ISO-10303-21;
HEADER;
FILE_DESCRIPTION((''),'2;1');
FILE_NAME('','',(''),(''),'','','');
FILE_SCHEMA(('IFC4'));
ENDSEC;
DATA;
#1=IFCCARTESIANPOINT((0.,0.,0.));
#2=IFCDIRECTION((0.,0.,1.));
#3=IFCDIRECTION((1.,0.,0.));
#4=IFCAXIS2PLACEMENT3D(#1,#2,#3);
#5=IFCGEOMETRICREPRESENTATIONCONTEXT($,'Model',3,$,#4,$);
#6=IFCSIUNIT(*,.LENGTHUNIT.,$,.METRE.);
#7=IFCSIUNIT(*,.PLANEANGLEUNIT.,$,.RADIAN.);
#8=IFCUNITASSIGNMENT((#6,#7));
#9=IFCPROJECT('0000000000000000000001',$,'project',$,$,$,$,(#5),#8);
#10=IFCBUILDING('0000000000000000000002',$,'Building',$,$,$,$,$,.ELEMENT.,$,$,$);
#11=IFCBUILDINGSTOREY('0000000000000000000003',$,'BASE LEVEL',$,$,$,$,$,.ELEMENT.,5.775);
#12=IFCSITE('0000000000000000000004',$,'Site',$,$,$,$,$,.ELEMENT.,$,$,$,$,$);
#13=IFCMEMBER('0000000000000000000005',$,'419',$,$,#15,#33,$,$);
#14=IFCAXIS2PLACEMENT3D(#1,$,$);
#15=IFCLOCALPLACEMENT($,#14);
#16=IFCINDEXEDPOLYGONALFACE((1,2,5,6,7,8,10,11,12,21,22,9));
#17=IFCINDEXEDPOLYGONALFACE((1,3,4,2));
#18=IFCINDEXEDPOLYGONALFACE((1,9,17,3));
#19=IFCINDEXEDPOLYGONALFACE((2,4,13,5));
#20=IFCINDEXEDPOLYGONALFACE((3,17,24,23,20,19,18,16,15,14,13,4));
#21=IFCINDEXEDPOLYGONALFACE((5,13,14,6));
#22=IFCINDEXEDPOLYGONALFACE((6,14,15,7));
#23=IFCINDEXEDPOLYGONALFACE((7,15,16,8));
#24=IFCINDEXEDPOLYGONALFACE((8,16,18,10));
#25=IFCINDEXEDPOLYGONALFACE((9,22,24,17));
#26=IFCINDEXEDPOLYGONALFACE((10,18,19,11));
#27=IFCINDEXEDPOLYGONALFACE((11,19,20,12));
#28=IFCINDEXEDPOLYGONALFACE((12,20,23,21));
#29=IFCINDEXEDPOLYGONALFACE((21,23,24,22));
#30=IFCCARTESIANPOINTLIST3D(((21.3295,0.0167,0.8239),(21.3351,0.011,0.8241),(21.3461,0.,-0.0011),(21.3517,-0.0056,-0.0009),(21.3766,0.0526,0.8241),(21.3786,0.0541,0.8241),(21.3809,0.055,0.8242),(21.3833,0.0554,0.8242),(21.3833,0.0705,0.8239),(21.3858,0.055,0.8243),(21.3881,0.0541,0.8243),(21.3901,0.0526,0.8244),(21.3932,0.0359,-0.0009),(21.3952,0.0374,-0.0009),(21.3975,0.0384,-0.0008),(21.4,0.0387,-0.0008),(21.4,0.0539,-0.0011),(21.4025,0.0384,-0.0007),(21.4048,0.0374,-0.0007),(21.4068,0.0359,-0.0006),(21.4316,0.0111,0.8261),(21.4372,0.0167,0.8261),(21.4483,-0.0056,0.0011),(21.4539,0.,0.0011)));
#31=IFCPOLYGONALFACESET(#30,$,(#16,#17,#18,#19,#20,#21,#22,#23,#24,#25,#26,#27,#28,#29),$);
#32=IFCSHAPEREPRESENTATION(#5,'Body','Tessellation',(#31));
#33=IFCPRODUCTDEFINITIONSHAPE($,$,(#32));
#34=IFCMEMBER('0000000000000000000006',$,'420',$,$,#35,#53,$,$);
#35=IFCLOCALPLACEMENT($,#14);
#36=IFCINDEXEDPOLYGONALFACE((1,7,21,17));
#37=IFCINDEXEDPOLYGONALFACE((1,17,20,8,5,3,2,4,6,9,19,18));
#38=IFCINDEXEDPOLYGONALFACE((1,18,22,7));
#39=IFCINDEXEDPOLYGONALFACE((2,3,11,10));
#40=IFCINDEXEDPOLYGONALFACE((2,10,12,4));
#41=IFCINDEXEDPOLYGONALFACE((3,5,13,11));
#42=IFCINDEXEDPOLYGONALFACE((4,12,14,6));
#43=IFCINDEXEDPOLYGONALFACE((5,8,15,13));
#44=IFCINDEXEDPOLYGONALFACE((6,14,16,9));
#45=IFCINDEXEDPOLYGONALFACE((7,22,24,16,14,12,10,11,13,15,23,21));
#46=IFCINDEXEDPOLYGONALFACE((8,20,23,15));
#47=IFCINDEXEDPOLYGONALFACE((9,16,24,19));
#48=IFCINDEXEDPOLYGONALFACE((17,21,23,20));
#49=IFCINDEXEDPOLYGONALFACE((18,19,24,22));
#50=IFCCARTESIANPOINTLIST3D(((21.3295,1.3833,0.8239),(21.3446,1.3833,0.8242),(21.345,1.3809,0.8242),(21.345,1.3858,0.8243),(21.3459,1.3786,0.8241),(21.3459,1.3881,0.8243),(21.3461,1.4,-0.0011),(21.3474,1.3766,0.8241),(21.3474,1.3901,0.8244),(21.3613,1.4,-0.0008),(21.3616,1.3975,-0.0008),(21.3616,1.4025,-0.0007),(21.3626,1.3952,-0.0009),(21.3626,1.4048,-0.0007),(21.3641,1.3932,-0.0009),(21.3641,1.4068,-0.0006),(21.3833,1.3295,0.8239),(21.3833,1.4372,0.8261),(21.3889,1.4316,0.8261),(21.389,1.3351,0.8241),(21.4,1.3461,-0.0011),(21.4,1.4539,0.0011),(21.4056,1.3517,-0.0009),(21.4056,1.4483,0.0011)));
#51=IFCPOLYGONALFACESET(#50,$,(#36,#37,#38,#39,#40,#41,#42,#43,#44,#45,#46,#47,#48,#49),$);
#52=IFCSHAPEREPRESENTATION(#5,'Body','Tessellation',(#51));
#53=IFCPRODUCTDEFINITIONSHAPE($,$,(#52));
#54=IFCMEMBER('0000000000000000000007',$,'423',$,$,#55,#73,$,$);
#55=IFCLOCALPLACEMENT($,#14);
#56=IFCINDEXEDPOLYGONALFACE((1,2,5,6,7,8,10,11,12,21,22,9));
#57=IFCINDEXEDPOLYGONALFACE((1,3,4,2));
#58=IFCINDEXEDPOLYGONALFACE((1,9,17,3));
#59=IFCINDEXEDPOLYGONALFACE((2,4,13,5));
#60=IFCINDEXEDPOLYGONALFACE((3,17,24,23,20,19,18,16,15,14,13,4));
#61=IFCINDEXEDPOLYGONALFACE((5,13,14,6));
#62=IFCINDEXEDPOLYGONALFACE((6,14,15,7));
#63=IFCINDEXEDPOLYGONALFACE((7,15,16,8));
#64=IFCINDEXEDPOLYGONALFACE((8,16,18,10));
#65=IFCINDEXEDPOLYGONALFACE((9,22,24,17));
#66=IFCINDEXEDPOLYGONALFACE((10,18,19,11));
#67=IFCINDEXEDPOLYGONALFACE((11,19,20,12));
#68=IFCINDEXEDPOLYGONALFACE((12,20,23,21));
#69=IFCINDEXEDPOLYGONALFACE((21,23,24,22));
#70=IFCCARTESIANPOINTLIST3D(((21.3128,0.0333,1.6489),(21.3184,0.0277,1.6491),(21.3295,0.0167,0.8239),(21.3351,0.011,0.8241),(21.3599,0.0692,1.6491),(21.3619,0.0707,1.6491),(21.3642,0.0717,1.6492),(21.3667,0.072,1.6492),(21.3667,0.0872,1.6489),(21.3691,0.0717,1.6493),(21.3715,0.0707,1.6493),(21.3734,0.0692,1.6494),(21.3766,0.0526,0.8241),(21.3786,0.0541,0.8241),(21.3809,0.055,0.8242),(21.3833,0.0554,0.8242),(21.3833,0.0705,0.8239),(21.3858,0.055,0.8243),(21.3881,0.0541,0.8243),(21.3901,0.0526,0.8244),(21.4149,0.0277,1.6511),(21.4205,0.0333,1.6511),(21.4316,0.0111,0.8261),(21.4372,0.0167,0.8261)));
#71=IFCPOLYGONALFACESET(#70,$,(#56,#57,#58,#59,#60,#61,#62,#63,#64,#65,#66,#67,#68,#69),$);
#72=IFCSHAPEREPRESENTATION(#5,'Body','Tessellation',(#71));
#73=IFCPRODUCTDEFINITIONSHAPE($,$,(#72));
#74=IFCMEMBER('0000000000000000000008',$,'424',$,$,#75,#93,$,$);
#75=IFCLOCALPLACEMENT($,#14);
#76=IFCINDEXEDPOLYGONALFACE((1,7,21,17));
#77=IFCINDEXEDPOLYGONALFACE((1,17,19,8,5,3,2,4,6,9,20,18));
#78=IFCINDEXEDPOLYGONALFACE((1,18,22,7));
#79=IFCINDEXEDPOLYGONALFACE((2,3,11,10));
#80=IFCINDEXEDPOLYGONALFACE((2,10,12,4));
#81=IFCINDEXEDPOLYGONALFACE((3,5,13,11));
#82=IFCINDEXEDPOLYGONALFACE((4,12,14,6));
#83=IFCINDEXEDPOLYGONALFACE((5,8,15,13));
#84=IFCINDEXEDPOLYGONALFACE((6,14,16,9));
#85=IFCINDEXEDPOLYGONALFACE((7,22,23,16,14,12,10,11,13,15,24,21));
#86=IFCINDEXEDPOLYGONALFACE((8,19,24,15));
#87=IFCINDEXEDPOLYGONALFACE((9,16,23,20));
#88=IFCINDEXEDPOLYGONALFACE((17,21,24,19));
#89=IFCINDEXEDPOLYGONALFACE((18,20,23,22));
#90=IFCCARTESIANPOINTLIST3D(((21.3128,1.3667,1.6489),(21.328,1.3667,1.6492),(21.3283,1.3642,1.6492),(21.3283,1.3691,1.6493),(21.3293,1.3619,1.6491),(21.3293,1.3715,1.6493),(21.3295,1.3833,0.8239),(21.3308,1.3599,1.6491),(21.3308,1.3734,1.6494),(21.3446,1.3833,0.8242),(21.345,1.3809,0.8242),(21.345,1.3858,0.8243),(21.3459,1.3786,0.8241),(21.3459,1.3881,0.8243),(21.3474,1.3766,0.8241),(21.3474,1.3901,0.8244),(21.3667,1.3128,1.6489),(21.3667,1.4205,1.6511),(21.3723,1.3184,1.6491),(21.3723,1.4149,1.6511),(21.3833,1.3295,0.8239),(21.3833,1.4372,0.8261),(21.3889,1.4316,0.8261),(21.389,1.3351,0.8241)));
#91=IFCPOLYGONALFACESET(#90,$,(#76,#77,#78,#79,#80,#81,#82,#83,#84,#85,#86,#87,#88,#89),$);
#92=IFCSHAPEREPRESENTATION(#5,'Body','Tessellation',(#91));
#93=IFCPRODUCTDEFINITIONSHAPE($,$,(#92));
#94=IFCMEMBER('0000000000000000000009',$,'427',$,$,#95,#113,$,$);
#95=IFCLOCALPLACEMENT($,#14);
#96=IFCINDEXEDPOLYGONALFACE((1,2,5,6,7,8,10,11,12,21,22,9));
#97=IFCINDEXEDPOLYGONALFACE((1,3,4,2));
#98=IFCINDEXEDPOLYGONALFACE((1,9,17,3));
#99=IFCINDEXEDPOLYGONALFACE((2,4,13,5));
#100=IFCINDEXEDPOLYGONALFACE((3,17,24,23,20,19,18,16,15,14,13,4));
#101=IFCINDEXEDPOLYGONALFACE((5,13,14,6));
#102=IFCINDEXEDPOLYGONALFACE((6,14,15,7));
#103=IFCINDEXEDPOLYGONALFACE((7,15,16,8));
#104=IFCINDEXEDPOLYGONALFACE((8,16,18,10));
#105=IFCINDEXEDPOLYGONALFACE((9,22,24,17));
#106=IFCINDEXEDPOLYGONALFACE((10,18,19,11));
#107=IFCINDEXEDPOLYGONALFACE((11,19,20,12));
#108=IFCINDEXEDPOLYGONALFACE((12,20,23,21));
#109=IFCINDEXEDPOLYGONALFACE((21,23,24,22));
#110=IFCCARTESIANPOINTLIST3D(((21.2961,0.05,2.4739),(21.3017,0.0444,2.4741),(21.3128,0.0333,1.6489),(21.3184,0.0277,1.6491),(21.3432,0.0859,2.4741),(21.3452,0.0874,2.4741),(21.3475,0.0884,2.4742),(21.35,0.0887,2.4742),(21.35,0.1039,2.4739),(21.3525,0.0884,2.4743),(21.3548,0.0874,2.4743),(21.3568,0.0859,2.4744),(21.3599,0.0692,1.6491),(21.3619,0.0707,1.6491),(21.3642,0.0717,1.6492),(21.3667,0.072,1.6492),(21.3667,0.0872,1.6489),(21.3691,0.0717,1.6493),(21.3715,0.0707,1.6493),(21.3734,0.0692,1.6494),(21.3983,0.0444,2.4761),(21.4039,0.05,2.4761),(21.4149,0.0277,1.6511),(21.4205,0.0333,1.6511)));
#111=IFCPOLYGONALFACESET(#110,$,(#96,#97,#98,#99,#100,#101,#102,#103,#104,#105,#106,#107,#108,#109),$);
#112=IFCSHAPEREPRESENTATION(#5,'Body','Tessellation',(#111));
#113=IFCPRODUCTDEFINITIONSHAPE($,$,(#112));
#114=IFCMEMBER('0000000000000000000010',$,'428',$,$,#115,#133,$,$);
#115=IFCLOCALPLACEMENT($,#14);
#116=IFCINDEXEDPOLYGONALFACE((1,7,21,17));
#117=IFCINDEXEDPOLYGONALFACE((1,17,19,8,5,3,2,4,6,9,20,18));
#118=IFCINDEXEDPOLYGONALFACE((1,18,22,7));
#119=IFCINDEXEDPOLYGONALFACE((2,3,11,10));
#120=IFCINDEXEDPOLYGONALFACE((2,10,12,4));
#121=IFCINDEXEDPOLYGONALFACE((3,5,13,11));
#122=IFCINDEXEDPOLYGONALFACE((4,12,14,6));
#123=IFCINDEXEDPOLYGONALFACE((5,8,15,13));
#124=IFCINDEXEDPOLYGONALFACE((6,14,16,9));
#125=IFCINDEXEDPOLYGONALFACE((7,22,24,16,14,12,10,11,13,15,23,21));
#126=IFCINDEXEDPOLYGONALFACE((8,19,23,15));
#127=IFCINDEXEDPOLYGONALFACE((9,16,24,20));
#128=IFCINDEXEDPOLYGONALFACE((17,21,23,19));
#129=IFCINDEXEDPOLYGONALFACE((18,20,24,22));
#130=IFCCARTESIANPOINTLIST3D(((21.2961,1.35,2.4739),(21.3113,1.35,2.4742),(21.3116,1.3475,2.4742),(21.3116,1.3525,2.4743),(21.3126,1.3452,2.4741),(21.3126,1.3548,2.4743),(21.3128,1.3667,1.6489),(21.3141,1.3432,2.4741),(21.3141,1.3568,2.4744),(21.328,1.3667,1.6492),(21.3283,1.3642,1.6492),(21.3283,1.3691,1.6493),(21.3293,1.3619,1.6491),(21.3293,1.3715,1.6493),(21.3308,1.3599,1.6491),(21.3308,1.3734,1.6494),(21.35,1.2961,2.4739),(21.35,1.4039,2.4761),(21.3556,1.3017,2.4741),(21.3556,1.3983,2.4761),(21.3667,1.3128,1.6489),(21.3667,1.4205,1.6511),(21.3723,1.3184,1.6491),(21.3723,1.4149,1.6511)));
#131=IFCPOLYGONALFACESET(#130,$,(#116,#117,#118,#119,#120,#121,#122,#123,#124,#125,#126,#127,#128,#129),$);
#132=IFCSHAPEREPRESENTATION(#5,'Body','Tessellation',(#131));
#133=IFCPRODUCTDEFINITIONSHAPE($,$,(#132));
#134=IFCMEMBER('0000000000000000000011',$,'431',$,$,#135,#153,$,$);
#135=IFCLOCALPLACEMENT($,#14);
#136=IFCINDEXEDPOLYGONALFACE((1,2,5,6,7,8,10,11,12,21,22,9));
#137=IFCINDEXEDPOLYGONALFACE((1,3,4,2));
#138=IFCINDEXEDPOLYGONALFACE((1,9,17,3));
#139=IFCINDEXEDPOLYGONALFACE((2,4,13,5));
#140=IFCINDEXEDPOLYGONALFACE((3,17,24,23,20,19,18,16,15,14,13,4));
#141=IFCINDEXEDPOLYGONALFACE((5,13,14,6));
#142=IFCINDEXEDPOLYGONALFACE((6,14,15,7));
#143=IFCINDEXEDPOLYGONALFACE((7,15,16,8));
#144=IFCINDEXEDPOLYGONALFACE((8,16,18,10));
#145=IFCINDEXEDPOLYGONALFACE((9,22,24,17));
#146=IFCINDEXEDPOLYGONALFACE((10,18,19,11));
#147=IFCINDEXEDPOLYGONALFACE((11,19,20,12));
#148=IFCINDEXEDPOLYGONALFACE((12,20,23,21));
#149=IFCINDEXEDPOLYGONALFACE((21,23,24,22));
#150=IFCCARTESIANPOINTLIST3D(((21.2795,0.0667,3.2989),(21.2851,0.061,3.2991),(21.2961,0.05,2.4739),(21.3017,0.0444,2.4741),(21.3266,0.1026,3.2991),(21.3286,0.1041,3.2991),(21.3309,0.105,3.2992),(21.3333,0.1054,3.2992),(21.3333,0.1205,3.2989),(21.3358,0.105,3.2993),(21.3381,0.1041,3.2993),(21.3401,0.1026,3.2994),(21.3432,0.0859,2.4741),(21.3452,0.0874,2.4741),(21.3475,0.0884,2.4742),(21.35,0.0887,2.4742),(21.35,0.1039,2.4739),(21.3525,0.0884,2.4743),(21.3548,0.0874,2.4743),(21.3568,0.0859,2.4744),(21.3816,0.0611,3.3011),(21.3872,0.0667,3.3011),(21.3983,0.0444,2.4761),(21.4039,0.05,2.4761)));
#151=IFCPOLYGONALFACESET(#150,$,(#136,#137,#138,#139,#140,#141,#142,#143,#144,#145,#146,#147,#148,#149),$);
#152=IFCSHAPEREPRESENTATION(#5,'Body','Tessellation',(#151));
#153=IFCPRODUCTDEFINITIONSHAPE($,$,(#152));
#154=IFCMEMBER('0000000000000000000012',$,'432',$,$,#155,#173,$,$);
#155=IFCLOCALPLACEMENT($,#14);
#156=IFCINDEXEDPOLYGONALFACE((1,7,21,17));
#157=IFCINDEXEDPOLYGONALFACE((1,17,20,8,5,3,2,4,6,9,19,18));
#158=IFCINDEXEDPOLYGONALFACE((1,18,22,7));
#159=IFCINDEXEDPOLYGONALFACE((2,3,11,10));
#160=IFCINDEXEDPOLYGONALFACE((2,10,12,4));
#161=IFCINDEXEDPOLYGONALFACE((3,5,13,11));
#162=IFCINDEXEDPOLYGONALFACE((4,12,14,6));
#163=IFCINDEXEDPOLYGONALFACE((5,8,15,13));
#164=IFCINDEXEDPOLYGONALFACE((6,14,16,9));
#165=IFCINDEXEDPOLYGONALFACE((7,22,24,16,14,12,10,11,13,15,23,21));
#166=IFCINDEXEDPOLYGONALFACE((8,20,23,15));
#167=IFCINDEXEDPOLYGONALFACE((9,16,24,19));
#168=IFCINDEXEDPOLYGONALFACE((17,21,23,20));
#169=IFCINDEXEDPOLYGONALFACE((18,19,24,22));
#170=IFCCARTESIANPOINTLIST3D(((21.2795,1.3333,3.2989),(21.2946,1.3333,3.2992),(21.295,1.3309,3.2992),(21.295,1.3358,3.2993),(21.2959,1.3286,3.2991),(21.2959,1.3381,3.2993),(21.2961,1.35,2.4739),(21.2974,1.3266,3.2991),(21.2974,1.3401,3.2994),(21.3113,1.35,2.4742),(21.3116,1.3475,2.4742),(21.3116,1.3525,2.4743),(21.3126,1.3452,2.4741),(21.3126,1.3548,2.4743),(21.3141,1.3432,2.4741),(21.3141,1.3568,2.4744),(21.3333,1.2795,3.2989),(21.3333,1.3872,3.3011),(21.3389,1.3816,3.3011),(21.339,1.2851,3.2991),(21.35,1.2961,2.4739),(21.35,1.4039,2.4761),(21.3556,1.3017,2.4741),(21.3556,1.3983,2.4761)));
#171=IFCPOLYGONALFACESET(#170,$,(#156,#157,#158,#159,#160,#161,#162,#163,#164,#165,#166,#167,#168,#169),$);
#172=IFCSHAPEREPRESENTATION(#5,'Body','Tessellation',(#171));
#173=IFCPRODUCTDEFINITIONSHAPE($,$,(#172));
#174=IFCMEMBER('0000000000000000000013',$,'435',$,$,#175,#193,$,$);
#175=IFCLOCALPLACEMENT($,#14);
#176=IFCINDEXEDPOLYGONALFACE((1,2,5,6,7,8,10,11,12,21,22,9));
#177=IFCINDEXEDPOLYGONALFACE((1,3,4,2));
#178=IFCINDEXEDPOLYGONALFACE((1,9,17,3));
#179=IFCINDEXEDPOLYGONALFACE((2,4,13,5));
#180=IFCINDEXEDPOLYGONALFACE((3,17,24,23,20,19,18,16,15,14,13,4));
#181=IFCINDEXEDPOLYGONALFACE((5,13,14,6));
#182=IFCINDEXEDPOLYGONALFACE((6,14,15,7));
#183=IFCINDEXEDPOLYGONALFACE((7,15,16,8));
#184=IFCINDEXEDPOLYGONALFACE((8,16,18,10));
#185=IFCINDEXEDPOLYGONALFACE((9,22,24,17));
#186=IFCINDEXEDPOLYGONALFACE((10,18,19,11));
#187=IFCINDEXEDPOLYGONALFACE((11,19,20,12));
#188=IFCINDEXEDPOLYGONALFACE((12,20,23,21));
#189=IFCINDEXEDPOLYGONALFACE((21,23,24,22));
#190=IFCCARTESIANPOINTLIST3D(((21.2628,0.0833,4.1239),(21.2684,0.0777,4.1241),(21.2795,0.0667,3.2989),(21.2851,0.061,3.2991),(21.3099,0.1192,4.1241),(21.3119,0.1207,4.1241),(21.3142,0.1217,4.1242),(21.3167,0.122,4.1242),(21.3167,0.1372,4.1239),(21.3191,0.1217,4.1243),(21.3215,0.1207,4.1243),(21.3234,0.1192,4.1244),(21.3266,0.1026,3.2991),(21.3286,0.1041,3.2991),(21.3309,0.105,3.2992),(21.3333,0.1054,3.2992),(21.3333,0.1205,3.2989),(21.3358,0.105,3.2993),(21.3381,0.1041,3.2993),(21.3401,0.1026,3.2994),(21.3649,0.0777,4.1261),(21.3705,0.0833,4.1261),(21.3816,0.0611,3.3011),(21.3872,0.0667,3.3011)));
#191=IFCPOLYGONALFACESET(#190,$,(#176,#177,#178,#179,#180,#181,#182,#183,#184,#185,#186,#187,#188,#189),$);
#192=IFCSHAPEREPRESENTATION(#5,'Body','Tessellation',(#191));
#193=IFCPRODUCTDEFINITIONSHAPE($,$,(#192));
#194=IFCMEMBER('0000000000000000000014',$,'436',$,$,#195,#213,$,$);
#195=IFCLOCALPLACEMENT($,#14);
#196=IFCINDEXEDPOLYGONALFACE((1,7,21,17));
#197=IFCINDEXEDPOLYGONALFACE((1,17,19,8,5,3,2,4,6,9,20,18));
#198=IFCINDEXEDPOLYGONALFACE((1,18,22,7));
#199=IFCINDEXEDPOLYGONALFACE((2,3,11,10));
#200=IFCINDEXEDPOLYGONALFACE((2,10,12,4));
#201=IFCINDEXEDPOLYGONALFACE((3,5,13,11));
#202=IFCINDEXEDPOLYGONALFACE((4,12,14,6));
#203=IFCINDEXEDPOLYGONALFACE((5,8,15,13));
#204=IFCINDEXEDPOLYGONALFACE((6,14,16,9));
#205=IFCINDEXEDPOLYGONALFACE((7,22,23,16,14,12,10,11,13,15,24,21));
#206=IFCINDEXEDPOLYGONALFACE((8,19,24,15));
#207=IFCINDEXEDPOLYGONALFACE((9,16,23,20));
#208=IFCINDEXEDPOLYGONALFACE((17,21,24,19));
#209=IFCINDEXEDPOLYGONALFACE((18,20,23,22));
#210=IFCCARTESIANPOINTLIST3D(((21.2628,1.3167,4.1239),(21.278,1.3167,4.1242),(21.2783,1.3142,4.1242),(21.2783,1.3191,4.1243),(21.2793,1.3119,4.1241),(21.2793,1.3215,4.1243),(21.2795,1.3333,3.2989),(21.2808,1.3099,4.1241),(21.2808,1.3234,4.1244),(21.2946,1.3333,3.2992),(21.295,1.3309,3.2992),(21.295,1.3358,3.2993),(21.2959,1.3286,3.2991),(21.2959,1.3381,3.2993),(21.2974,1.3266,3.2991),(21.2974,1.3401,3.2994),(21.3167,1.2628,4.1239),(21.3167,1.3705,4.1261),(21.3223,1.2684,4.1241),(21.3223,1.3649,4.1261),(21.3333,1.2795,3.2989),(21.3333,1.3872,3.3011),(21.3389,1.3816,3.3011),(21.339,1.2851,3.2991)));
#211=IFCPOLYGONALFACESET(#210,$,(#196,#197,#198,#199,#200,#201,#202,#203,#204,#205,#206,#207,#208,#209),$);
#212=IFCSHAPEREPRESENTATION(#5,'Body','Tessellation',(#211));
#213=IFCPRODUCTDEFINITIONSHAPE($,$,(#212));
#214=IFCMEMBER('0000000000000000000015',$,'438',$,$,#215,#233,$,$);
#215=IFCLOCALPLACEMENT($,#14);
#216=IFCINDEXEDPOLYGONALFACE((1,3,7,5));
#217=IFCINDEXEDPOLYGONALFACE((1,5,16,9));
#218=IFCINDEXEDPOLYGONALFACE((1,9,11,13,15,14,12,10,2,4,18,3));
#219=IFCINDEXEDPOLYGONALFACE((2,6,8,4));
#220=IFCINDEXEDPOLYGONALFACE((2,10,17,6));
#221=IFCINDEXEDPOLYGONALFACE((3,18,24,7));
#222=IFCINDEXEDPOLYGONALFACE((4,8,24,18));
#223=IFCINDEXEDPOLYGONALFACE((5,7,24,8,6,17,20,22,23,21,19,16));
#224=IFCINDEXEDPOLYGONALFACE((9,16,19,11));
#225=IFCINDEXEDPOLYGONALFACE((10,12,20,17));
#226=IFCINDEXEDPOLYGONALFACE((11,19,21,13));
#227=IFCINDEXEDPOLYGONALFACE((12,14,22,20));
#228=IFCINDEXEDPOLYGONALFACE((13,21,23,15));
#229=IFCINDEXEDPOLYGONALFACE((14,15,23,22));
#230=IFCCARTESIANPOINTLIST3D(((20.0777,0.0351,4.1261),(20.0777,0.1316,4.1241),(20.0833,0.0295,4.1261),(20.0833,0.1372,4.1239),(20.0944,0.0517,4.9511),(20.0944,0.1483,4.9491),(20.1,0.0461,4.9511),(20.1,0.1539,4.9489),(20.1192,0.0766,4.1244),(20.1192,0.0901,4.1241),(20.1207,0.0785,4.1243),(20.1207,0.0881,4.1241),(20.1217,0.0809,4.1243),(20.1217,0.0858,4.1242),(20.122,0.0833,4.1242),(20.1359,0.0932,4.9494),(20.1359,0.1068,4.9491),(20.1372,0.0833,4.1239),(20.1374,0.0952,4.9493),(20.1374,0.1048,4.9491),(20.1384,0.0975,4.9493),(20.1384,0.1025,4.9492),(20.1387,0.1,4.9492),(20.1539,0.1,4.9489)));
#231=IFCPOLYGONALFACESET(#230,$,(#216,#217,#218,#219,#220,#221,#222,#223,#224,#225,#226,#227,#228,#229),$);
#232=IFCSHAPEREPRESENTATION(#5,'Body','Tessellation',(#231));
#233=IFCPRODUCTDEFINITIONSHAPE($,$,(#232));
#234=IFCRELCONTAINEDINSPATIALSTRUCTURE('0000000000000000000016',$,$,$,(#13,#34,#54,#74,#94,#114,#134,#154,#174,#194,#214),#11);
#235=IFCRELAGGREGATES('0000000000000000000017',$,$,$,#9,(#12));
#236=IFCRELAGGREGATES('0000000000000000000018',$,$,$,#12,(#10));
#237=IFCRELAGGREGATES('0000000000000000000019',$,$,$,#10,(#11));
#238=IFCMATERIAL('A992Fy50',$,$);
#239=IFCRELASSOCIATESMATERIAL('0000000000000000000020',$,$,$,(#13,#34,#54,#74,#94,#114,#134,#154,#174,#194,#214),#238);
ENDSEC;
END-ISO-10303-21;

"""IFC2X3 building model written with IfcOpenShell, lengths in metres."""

from ifc_helpers import new_model, si_unit, frame, origin_with_axes, origin_2d_with_axis, place, context, project, spatial, l_section, extrude, material, element, save


model = new_model("IFC2X3")

# Units and contexts
model_context = context("Model", 3, world=origin_with_axes())
ifc_project = project(units=[si_unit("LENGTHUNIT", "METRE"), si_unit("PLANEANGLEUNIT", "RADIAN")], contexts=[model_context])

# Site, building, storey
site = spatial("IfcSite", under=ifc_project, Name="Site", CompositionType="ELEMENT")
building = spatial("IfcBuilding", under=site, Name="Building", CompositionType="ELEMENT")
storey = spatial("IfcBuildingStorey", under=building, Name="BASE LEVEL", CompositionType="ELEMENT", Elevation=5.775)

# Members
ifc_material = material(Name="A992Fy50")
for number, where, z_axis, x_axis, name in (
    (1, (21.4, 0.0, 0.0), (-0.020194, 0.020194, 0.999592), (-0.707107, -0.707107, 0.0), "419"),
    (2, (21.4, 1.4, 0.0), (-0.020194, -0.020194, 0.999592), (0.707107, -0.707107, 0.0), "420"),
    (3, (21.3833, 0.0167, 0.825), (-0.020194, 0.020194, 0.999592), (-0.707107, -0.707107, 0.0), "423"),
    (4, (21.3833, 1.3833, 0.825), (-0.020194, -0.020194, 0.999592), (0.707107, -0.707107, 0.0), "424"),
    (5, (21.3667, 0.0333, 1.65), (-0.020194, 0.020194, 0.999592), (-0.707107, -0.707107, 0.0), "427"),
    (6, (21.3667, 1.3667, 1.65), (-0.020194, -0.020194, 0.999592), (0.707107, -0.707107, 0.0), "428"),
    (7, (21.35, 0.05, 2.475), (-0.020194, 0.020194, 0.999592), (-0.707107, -0.707107, 0.0), "431"),
    (8, (21.35, 1.35, 2.475), (-0.020194, -0.020194, 0.999592), (0.707107, -0.707107, 0.0), "432"),
    (9, (21.3333, 0.0667, 3.3), (-0.020194, 0.020194, 0.999592), (-0.707107, -0.707107, 0.0), "435"),
    (10, (21.3333, 1.3333, 3.3), (-0.020194, -0.020194, 0.999592), (0.707107, -0.707107, 0.0), "436"),
    (11, (20.0833, 0.0833, 4.125), (0.020194, 0.020194, 0.999592), (-0.707107, 0.707107, 0.0), "438"),
):
    element("IfcMember", number, at=place(None, frame(where, z_axis=z_axis, x_axis=x_axis)), inside=storey, material=ifc_material, Name=name, context=model_context, shape_type="SweptSolid", body=[
        extrude(l_section(Depth=0.0762, Width=0.0762, Thickness=0.0079, FilletRadius=0.0096, at=origin_2d_with_axis()), origin_with_axes(), (0.0, 0.0, 1.0), 0.8253),
    ])

save(model, "model.ifc")
